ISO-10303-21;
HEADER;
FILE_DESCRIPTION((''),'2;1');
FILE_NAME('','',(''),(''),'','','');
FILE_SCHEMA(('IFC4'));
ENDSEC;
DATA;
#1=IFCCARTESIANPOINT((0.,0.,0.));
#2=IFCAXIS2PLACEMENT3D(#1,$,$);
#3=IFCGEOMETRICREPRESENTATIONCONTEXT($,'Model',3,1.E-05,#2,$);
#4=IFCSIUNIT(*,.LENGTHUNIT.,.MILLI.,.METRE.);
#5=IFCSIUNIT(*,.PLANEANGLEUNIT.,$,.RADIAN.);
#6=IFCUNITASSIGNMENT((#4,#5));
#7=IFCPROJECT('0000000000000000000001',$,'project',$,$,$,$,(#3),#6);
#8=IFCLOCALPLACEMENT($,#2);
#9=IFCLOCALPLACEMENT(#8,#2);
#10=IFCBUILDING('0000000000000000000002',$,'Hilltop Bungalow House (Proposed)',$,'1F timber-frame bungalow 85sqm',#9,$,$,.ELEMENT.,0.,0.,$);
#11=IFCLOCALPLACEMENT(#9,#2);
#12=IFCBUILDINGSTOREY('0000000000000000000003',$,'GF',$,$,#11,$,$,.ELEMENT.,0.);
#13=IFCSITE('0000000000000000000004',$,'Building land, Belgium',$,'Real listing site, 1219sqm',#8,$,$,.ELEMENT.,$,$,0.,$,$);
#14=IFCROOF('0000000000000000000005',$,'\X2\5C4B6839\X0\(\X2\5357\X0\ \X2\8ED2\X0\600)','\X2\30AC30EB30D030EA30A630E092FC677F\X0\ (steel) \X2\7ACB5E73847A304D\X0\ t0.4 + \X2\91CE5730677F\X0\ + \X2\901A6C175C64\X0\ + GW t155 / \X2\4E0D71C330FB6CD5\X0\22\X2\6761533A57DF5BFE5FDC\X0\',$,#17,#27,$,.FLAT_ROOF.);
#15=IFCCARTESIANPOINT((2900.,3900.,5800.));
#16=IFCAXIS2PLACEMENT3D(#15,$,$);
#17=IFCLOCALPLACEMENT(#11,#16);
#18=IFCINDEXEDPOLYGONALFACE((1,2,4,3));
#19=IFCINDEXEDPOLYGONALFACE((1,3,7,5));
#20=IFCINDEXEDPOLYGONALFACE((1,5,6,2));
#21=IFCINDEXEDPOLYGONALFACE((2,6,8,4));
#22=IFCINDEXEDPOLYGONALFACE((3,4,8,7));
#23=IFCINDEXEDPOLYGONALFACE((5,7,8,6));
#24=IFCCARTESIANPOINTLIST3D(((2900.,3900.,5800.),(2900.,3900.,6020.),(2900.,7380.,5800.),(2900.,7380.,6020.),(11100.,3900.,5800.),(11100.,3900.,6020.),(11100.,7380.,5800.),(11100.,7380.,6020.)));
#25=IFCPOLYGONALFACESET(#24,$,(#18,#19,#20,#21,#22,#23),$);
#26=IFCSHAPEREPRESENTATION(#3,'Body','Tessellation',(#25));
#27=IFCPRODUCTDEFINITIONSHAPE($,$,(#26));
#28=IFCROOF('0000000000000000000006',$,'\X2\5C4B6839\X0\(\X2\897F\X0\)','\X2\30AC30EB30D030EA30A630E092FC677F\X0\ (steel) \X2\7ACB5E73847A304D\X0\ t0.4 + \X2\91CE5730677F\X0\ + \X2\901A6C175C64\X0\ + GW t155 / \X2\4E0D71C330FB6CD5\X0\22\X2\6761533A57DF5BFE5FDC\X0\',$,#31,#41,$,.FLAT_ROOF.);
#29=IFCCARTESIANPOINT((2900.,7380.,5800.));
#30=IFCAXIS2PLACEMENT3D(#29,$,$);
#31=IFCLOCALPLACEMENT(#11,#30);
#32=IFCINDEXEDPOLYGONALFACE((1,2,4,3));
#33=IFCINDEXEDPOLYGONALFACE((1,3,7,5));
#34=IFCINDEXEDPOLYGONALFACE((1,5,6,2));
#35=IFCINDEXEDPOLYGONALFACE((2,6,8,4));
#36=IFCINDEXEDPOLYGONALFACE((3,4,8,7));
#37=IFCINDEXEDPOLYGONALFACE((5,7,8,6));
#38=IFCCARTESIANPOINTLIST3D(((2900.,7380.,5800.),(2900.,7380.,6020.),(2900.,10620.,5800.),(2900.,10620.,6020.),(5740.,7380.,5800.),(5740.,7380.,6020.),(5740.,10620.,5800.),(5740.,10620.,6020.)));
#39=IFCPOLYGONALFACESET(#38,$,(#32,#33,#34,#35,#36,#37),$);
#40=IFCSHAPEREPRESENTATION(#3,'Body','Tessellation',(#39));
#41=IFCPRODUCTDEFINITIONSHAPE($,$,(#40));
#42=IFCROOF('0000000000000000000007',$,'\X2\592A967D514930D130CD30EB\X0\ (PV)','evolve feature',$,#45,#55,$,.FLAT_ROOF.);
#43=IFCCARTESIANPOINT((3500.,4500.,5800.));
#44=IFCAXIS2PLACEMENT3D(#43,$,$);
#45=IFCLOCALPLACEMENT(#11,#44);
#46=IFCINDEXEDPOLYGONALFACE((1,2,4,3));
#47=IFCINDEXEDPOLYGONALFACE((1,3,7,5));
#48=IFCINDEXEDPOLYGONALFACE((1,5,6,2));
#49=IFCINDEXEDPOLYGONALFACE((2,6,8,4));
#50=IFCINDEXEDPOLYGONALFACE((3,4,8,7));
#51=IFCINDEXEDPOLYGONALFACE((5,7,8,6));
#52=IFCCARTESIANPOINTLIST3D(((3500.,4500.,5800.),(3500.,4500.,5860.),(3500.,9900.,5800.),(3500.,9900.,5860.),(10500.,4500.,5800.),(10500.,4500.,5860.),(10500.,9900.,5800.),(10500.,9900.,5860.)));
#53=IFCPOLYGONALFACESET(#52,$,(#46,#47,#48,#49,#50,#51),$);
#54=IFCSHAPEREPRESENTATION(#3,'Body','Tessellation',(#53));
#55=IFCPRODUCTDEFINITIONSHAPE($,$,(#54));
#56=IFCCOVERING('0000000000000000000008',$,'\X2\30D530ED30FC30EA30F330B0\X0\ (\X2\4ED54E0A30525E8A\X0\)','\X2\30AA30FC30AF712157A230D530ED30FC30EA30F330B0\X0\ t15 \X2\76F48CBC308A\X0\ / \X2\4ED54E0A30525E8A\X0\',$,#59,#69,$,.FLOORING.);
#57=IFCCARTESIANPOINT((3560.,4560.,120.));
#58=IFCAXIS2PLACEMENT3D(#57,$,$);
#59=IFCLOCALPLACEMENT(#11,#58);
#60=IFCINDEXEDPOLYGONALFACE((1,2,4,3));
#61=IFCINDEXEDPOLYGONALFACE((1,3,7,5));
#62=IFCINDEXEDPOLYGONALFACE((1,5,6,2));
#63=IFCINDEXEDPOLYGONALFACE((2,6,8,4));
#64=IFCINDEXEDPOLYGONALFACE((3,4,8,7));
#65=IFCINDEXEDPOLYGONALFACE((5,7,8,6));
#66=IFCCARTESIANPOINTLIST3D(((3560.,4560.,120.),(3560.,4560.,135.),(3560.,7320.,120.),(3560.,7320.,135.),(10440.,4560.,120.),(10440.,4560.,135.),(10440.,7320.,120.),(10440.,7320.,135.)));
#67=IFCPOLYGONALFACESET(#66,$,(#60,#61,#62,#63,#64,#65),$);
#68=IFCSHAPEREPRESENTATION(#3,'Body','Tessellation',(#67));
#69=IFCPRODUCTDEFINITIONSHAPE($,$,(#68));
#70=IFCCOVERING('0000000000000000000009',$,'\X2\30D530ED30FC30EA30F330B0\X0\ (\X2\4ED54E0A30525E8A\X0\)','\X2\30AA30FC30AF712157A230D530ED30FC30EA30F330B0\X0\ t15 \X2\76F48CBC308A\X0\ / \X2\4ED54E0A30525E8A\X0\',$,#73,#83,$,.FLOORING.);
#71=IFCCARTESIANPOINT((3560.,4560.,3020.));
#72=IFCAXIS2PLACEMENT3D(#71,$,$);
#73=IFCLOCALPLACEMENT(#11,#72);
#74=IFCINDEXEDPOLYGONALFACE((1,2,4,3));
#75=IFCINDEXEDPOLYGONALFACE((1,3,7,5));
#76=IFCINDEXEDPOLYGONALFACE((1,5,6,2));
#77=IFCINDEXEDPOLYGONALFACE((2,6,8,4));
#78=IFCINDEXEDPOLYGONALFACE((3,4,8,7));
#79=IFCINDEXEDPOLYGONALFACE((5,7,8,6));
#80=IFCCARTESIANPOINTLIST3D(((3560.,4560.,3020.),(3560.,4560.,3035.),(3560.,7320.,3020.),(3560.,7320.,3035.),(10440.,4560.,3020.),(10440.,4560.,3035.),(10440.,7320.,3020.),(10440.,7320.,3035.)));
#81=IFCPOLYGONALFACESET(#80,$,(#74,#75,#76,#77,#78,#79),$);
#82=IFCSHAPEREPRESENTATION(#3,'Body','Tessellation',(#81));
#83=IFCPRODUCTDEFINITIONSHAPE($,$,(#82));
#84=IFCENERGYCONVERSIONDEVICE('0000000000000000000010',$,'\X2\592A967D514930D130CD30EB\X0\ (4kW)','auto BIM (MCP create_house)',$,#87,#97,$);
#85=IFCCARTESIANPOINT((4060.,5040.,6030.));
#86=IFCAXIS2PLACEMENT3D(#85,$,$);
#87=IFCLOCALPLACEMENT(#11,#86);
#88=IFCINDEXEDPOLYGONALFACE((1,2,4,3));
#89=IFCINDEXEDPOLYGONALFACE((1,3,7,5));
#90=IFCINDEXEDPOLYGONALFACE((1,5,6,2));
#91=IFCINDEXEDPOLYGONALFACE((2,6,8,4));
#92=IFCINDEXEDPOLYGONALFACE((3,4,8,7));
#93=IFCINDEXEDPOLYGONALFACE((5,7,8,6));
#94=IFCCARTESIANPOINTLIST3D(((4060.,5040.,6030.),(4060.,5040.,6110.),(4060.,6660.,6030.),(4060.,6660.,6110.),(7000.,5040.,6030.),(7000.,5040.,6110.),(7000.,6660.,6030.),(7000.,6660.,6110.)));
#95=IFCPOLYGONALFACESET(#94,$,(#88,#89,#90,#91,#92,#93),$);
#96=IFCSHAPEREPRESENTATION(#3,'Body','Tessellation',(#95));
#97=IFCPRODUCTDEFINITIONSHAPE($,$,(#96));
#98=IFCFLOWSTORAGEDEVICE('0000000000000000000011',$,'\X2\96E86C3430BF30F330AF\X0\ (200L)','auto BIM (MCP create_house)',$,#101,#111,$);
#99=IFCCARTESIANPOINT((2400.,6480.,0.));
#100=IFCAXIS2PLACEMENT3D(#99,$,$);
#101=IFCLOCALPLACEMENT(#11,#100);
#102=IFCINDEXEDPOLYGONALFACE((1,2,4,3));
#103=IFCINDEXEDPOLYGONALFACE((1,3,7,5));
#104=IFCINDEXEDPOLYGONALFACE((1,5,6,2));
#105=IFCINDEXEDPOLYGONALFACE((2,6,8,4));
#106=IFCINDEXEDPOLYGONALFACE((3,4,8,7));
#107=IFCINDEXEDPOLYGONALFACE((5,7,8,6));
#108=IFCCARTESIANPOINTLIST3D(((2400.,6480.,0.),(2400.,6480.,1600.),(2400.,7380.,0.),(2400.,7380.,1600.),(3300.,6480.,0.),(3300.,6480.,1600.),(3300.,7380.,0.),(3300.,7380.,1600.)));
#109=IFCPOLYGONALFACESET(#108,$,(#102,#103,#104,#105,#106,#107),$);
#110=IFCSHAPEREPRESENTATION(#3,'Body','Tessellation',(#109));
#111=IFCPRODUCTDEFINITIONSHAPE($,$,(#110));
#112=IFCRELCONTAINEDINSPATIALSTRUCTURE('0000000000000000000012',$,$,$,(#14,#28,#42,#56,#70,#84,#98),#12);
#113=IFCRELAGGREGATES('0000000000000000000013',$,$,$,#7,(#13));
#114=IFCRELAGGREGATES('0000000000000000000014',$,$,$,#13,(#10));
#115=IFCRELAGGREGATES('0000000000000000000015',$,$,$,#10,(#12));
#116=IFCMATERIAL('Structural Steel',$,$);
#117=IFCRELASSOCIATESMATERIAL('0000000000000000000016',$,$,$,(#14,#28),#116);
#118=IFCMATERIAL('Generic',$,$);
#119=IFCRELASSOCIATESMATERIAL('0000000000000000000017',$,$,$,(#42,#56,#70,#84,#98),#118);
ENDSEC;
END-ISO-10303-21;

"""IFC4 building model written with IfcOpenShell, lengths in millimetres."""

from ifc_helpers import new_model, si_unit, frame, frame_2d, origin, place, context, project, spatial, rectangle, extrude, material, element, save


model = new_model("IFC4")

# Units and contexts
model_context = context("Model", 3, precision=1e-05, world=origin())
ifc_project = project(units=[si_unit("LENGTHUNIT", "METRE", prefix="MILLI"), si_unit("PLANEANGLEUNIT", "RADIAN")], contexts=[model_context])

# Site, building, storey
site_placement = place(None, origin())
site = spatial("IfcSite", under=ifc_project, at=site_placement, Name="Building land, Belgium", ObjectType="Real listing site, 1219sqm", CompositionType="ELEMENT", RefElevation=0.0)
building_placement = place(site_placement, origin())
building = spatial("IfcBuilding", under=site, at=building_placement, Name="Hilltop Bungalow House (Proposed)", ObjectType="1F timber-frame bungalow 85sqm", CompositionType="ELEMENT", ElevationOfRefHeight=0.0, ElevationOfTerrain=0.0)
storey_placement = place(building_placement, origin())
storey = spatial("IfcBuildingStorey", under=building, at=storey_placement, Name="GF", CompositionType="ELEMENT", Elevation=0.0)

# Shared definitions
ifc_material_1 = material(Name="Generic")

# Roofs
ifc_material_2 = material(Name="Structural Steel")
roof_1_placement = place(storey_placement, frame((2900.0, 3900.0, 5800.0)))
element("IfcRoof", 1, at=roof_1_placement, inside=storey, material=ifc_material_2, Name="屋根(南 軒600)", Description="ガルバリウム鋼板 (steel) 立平葺き t0.4 + 野地板 + 通気層 + GW t155 / 不燃・法22条区域対応", PredefinedType="FLAT_ROOF", context=model_context, shape_type="SweptSolid", body=[
    extrude(rectangle(XDim=8200.0, YDim=3480.0, at=frame_2d((4100.0, 1740.0))), frame((2900.0, 3900.0, 5800.0)), (0.0, 0.0, 1.0), 220.0),
])
roof_2_placement = place(storey_placement, frame((2900.0, 7380.0, 5800.0)))
element("IfcRoof", 2, at=roof_2_placement, inside=storey, material=ifc_material_2, Name="屋根(西)", Description="ガルバリウム鋼板 (steel) 立平葺き t0.4 + 野地板 + 通気層 + GW t155 / 不燃・法22条区域対応", PredefinedType="FLAT_ROOF", context=model_context, shape_type="SweptSolid", body=[
    extrude(rectangle(XDim=2840.0, YDim=3240.0, at=frame_2d((1420.0, 1620.0))), frame((2900.0, 7380.0, 5800.0)), (0.0, 0.0, 1.0), 220.0),
])
roof_3_placement = place(storey_placement, frame((3500.0, 4500.0, 5800.0)))
element("IfcRoof", 3, at=roof_3_placement, inside=storey, material=ifc_material_1, Name="太陽光パネル (PV)", Description="evolve feature", PredefinedType="FLAT_ROOF", context=model_context, shape_type="SweptSolid", body=[
    extrude(rectangle(XDim=7000.0, YDim=5400.0, at=frame_2d((3500.0, 2700.0))), frame((3500.0, 4500.0, 5800.0)), (0.0, 0.0, 1.0), 60.0),
])

# Coverings
covering_1_placement = place(storey_placement, frame((3560.0, 4560.0, 120.0)))
element("IfcCovering", 4, at=covering_1_placement, inside=storey, material=ifc_material_1, Name="フローリング (仕上げ床)", Description="オーク無垢フローリング t15 直貼り / 仕上げ床", PredefinedType="FLOORING", context=model_context, shape_type="SweptSolid", body=[
    extrude(rectangle(XDim=6880.0, YDim=2760.0, at=frame_2d((3440.0, 1380.0))), frame((3560.0, 4560.0, 120.0)), (0.0, 0.0, 1.0), 15.0),
])
covering_2_placement = place(storey_placement, frame((3560.0, 4560.0, 3020.0)))
element("IfcCovering", 5, at=covering_2_placement, inside=storey, material=ifc_material_1, Name="フローリング (仕上げ床)", Description="オーク無垢フローリング t15 直貼り / 仕上げ床", PredefinedType="FLOORING", context=model_context, shape_type="SweptSolid", body=[
    extrude(rectangle(XDim=6880.0, YDim=2760.0, at=frame_2d((3440.0, 1380.0))), frame((3560.0, 4560.0, 3020.0)), (0.0, 0.0, 1.0), 15.0),
])

# Energy conversion device
energy_conversion_device_placement = place(storey_placement, frame((4060.0, 5040.0, 6030.0)))
element("IfcEnergyConversionDevice", 6, at=energy_conversion_device_placement, inside=storey, material=ifc_material_1, Name="太陽光パネル (4kW)", Description="auto BIM (MCP create_house)", context=model_context, shape_type="SweptSolid", body=[
    extrude(rectangle(XDim=2940.0, YDim=1620.0, at=frame_2d((1470.0, 810.0))), frame((4060.0, 5040.0, 6030.0)), (0.0, 0.0, 1.0), 80.0),
])

# Flow storage device
flow_storage_device_placement = place(storey_placement, frame((2400.0, 6480.0, 0.0)))
element("IfcFlowStorageDevice", 7, at=flow_storage_device_placement, inside=storey, material=ifc_material_1, Name="雨水タンク (200L)", Description="auto BIM (MCP create_house)", context=model_context, shape_type="SweptSolid", body=[
    extrude(rectangle(XDim=900.0, YDim=900.0, at=frame_2d((450.0, 450.0))), frame((2400.0, 6480.0, 0.0)), (0.0, 0.0, 1.0), 1600.0),
])

save(model, "model.ifc")
